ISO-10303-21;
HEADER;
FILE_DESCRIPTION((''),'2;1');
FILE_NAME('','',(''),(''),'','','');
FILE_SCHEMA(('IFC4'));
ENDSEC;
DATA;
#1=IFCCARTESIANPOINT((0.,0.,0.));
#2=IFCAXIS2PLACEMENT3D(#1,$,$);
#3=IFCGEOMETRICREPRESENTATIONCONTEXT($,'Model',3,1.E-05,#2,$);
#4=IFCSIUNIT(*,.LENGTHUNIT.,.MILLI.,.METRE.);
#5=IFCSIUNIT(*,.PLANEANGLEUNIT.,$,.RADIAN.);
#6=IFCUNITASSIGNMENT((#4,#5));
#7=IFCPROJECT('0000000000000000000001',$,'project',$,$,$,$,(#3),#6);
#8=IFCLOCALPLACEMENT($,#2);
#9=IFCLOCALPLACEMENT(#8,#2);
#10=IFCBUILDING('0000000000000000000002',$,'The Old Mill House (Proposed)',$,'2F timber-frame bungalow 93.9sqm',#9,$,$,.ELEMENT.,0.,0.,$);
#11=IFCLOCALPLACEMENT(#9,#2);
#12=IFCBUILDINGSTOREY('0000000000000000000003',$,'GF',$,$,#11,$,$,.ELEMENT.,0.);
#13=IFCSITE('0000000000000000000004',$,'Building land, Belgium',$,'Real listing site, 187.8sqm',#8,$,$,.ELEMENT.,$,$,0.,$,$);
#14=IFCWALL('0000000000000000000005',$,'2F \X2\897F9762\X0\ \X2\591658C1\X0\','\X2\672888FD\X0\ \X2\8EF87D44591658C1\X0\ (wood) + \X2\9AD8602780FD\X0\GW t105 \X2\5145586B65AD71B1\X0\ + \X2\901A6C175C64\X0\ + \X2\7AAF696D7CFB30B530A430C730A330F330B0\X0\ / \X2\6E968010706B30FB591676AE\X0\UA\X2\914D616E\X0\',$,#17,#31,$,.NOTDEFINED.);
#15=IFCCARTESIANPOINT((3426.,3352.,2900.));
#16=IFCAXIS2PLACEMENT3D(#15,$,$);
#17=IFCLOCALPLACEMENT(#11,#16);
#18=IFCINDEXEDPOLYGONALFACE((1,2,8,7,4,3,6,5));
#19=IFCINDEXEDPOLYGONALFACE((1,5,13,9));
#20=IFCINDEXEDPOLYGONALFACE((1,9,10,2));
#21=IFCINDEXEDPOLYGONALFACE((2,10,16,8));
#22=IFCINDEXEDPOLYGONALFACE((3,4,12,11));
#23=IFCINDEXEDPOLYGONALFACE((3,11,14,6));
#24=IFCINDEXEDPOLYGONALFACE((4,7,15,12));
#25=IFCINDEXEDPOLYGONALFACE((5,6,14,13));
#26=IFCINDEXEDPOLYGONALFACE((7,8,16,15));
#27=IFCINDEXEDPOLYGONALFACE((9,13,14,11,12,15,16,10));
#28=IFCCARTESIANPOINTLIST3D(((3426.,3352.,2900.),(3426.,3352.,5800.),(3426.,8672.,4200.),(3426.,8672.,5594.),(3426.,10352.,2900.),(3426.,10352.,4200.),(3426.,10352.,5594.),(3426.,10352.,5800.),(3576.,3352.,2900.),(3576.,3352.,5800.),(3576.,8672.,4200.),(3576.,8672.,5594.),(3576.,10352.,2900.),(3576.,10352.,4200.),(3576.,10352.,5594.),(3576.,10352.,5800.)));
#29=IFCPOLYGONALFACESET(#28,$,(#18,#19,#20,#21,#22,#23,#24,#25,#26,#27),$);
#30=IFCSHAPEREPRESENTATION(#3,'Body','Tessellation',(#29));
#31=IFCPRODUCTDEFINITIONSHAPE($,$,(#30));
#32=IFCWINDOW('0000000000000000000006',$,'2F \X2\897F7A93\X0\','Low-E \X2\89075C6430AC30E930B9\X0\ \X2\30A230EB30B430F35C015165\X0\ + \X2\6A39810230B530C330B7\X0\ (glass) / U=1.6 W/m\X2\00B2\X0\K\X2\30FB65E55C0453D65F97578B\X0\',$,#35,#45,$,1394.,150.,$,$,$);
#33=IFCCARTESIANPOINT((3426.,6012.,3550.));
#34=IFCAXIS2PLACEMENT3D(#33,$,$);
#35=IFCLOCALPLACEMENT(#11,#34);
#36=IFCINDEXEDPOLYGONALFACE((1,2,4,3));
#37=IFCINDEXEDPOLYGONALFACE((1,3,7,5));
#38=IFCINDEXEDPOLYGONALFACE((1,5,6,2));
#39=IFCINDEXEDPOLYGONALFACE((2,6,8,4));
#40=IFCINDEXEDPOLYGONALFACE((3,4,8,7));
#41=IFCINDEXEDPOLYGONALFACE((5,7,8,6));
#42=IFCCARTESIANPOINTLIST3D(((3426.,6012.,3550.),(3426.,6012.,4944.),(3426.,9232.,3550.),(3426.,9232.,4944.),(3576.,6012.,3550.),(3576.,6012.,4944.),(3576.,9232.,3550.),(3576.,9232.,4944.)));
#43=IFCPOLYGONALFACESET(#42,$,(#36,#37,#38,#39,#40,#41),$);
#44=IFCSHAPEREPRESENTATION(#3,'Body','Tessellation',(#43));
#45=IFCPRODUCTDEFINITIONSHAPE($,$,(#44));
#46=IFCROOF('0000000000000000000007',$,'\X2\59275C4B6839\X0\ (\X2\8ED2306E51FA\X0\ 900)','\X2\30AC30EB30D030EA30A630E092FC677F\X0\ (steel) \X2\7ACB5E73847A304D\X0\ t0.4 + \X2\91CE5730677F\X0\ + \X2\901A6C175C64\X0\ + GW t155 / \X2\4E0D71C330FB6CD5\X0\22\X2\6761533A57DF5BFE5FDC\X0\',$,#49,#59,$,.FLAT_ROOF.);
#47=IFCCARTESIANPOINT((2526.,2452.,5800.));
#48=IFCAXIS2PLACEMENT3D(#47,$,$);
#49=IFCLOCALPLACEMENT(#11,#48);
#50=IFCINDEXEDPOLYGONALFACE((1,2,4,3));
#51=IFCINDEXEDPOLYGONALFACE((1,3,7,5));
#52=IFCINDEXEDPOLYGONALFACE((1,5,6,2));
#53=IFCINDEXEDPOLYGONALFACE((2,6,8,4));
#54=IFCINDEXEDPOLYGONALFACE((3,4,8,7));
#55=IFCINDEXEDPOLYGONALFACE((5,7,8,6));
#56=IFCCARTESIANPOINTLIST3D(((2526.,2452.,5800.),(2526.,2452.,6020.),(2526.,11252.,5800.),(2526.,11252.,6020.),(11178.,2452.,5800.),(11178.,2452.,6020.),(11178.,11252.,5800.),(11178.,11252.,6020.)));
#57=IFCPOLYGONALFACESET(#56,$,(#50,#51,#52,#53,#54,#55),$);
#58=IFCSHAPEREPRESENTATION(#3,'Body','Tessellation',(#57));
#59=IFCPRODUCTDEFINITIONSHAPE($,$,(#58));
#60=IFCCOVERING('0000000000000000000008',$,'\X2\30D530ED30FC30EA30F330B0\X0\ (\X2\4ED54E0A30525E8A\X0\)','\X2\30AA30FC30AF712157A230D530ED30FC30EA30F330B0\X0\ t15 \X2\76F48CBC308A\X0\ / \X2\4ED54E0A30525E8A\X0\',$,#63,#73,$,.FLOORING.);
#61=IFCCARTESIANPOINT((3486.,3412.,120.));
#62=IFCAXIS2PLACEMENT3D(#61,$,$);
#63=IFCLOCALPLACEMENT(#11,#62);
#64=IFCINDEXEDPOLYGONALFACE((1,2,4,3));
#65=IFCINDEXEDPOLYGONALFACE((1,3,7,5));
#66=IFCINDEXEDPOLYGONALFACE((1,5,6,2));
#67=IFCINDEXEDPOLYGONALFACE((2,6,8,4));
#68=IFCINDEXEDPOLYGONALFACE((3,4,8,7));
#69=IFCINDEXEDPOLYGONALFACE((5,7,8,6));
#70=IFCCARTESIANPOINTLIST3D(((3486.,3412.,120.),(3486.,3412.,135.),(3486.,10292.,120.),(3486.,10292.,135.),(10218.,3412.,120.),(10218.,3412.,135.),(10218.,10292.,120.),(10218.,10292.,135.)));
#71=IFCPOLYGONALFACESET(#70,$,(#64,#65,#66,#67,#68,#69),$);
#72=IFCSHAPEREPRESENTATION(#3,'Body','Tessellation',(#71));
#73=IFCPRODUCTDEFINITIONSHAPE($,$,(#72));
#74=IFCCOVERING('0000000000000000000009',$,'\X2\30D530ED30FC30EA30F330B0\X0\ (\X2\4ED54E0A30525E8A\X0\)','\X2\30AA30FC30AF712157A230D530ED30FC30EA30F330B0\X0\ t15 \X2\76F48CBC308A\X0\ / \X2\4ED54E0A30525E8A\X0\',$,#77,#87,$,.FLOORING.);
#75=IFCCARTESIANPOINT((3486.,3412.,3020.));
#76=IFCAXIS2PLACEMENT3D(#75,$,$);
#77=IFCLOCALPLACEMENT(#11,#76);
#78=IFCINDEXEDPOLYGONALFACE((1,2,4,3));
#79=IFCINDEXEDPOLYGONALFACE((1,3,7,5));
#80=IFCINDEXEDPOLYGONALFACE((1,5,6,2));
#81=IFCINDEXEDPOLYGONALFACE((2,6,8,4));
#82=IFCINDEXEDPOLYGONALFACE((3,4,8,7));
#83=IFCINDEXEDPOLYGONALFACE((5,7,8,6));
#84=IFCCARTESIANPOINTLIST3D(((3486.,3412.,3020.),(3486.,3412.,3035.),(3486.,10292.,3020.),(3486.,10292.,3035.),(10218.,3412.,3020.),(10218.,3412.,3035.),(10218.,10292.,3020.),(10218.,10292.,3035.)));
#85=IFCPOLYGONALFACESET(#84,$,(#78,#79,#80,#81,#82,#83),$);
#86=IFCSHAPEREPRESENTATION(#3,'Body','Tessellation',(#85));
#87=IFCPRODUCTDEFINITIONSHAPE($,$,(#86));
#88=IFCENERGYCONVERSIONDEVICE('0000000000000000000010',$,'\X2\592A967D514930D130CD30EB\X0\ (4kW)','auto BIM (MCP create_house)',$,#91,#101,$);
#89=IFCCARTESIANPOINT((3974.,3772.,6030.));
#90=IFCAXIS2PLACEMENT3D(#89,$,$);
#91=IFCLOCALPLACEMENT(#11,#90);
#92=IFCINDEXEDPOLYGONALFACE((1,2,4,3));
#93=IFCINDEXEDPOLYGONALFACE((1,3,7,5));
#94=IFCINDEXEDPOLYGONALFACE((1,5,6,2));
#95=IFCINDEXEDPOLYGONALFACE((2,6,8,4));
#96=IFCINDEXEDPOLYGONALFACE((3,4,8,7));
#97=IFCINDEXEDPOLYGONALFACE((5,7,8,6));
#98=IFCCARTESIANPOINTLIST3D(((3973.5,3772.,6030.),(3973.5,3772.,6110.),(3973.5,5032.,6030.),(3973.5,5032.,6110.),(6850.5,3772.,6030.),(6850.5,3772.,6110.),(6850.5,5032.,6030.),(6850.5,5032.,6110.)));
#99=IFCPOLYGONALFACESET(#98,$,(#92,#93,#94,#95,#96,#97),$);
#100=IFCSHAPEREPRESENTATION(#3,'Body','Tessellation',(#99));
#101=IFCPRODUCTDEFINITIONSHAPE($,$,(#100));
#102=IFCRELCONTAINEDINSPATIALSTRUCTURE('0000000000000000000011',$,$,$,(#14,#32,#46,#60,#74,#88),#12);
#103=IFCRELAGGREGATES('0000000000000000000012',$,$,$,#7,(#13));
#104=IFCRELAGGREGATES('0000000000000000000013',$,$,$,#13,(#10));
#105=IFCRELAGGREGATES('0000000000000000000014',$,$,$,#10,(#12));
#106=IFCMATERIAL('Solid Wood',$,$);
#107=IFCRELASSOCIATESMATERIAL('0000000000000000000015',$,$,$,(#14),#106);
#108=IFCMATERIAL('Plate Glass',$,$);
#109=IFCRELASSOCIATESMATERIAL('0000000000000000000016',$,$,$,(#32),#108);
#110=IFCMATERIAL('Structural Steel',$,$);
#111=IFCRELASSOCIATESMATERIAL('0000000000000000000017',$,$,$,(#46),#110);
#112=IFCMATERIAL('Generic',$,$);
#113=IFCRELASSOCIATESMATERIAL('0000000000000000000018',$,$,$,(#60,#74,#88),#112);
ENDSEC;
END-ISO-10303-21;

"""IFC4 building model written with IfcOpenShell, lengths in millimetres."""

from ifc_helpers import new_model, si_unit, frame, frame_2d, origin, place, context, project, spatial, rectangle, extrude, material, element, fill, save


model = new_model("IFC4")

# Units and contexts
model_context = context("Model", 3, precision=1e-05, world=origin())
ifc_project = project(units=[si_unit("LENGTHUNIT", "METRE", prefix="MILLI"), si_unit("PLANEANGLEUNIT", "RADIAN")], contexts=[model_context])

# Site, building, storey
site_placement = place(None, origin())
site = spatial("IfcSite", under=ifc_project, at=site_placement, Name="Building land, Belgium", ObjectType="Real listing site, 187.8sqm", CompositionType="ELEMENT", RefElevation=0.0)
building_placement = place(site_placement, origin())
building = spatial("IfcBuilding", under=site, at=building_placement, Name="The Old Mill House (Proposed)", ObjectType="2F timber-frame bungalow 93.9sqm", CompositionType="ELEMENT", ElevationOfRefHeight=0.0, ElevationOfTerrain=0.0)
storey_placement = place(building_placement, origin())
storey = spatial("IfcBuildingStorey", under=building, at=storey_placement, Name="GF", CompositionType="ELEMENT", Elevation=0.0)

# Shared definitions
ifc_material_1 = material(Name="Solid Wood")

# Shared definitions
ifc_material_2 = material(Name="Plate Glass")

# Wall, opening, window
wall_1_placement = place(storey_placement, frame((3426.0, 3352.0, 2900.0)))
wall_1 = element("IfcWall", 1, at=wall_1_placement, inside=storey, material=ifc_material_1, Name="2F 西面 外壁", Description="木製 軸組外壁 (wood) + 高性能GW t105 充填断熱 + 通気層 + 窯業系サイディング / 準耐火・外皮UA配慮", PredefinedType="NOTDEFINED", context=model_context, shape_type="SweptSolid", body=[
    extrude(rectangle(XDim=150.0, YDim=7000.0, at=frame_2d((75.0, 3500.0))), frame((3426.0, 3352.0, 2900.0)), (0.0, 0.0, 1.0), 2900.0),
])
opening_1_placement = place(storey_placement, frame((3426.0, 6012.0, 3550.0)))
opening_1 = element("IfcOpeningElement", 2, at=opening_1_placement, cuts=wall_1, PredefinedType="NOTDEFINED", context=model_context, shape_type="SweptSolid", body=[
    extrude(rectangle(XDim=150.0, YDim=3220.0, at=frame_2d((75.0, 1610.0))), frame((3426.0, 6012.0, 3550.0)), (0.0, 0.0, 1.0), 1394.0),
])
window_1_placement = place(storey_placement, frame((3426.0, 6012.0, 3550.0)))
window_1 = element("IfcWindow", 3, at=window_1_placement, inside=storey, material=ifc_material_2, Name="2F 西窓", Description="Low-E 複層ガラス アルゴン封入 + 樹脂サッシ (glass) / U=1.6 W/m²K・日射取得型", OverallHeight=1394.0, OverallWidth=150.0, context=model_context, shape_type="SweptSolid", body=[
    extrude(rectangle(XDim=150.0, YDim=3220.0, at=frame_2d((75.0, 1610.0))), frame((3426.0, 6012.0, 3550.0)), (0.0, 0.0, 1.0), 1394.0),
])
fill(opening_1, window_1)

# Roof
ifc_material_3 = material(Name="Structural Steel")
roof_placement = place(storey_placement, frame((2526.0, 2452.0, 5800.0)))
element("IfcRoof", 4, at=roof_placement, inside=storey, material=ifc_material_3, Name="大屋根 (軒の出 900)", Description="ガルバリウム鋼板 (steel) 立平葺き t0.4 + 野地板 + 通気層 + GW t155 / 不燃・法22条区域対応", PredefinedType="FLAT_ROOF", context=model_context, shape_type="SweptSolid", body=[
    extrude(rectangle(XDim=8652.0, YDim=8800.0, at=frame_2d((4326.0, 4400.0))), frame((2526.0, 2452.0, 5800.0)), (0.0, 0.0, 1.0), 220.0),
])

# Coverings
ifc_material_4 = material(Name="Generic")
covering_1_placement = place(storey_placement, frame((3486.0, 3412.0, 120.0)))
element("IfcCovering", 5, at=covering_1_placement, inside=storey, material=ifc_material_4, Name="フローリング (仕上げ床)", Description="オーク無垢フローリング t15 直貼り / 仕上げ床", PredefinedType="FLOORING", context=model_context, shape_type="SweptSolid", body=[
    extrude(rectangle(XDim=6732.0, YDim=6880.0, at=frame_2d((3366.0, 3440.0))), frame((3486.0, 3412.0, 120.0)), (0.0, 0.0, 1.0), 15.0),
])
covering_2_placement = place(storey_placement, frame((3486.0, 3412.0, 3020.0)))
element("IfcCovering", 6, at=covering_2_placement, inside=storey, material=ifc_material_4, Name="フローリング (仕上げ床)", Description="オーク無垢フローリング t15 直貼り / 仕上げ床", PredefinedType="FLOORING", context=model_context, shape_type="SweptSolid", body=[
    extrude(rectangle(XDim=6732.0, YDim=6880.0, at=frame_2d((3366.0, 3440.0))), frame((3486.0, 3412.0, 3020.0)), (0.0, 0.0, 1.0), 15.0),
])

# Energy conversion device
energy_conversion_device_placement = place(storey_placement, frame((3974.0, 3772.0, 6030.0)))
element("IfcEnergyConversionDevice", 7, at=energy_conversion_device_placement, inside=storey, material=ifc_material_4, Name="太陽光パネル (4kW)", Description="auto BIM (MCP create_house)", context=model_context, shape_type="SweptSolid", body=[
    extrude(rectangle(XDim=2877.0, YDim=1260.0, at=frame_2d((1438.0, 630.0))), frame((3974.0, 3772.0, 6030.0)), (0.0, 0.0, 1.0), 80.0),
])

save(model, "model.ifc")
